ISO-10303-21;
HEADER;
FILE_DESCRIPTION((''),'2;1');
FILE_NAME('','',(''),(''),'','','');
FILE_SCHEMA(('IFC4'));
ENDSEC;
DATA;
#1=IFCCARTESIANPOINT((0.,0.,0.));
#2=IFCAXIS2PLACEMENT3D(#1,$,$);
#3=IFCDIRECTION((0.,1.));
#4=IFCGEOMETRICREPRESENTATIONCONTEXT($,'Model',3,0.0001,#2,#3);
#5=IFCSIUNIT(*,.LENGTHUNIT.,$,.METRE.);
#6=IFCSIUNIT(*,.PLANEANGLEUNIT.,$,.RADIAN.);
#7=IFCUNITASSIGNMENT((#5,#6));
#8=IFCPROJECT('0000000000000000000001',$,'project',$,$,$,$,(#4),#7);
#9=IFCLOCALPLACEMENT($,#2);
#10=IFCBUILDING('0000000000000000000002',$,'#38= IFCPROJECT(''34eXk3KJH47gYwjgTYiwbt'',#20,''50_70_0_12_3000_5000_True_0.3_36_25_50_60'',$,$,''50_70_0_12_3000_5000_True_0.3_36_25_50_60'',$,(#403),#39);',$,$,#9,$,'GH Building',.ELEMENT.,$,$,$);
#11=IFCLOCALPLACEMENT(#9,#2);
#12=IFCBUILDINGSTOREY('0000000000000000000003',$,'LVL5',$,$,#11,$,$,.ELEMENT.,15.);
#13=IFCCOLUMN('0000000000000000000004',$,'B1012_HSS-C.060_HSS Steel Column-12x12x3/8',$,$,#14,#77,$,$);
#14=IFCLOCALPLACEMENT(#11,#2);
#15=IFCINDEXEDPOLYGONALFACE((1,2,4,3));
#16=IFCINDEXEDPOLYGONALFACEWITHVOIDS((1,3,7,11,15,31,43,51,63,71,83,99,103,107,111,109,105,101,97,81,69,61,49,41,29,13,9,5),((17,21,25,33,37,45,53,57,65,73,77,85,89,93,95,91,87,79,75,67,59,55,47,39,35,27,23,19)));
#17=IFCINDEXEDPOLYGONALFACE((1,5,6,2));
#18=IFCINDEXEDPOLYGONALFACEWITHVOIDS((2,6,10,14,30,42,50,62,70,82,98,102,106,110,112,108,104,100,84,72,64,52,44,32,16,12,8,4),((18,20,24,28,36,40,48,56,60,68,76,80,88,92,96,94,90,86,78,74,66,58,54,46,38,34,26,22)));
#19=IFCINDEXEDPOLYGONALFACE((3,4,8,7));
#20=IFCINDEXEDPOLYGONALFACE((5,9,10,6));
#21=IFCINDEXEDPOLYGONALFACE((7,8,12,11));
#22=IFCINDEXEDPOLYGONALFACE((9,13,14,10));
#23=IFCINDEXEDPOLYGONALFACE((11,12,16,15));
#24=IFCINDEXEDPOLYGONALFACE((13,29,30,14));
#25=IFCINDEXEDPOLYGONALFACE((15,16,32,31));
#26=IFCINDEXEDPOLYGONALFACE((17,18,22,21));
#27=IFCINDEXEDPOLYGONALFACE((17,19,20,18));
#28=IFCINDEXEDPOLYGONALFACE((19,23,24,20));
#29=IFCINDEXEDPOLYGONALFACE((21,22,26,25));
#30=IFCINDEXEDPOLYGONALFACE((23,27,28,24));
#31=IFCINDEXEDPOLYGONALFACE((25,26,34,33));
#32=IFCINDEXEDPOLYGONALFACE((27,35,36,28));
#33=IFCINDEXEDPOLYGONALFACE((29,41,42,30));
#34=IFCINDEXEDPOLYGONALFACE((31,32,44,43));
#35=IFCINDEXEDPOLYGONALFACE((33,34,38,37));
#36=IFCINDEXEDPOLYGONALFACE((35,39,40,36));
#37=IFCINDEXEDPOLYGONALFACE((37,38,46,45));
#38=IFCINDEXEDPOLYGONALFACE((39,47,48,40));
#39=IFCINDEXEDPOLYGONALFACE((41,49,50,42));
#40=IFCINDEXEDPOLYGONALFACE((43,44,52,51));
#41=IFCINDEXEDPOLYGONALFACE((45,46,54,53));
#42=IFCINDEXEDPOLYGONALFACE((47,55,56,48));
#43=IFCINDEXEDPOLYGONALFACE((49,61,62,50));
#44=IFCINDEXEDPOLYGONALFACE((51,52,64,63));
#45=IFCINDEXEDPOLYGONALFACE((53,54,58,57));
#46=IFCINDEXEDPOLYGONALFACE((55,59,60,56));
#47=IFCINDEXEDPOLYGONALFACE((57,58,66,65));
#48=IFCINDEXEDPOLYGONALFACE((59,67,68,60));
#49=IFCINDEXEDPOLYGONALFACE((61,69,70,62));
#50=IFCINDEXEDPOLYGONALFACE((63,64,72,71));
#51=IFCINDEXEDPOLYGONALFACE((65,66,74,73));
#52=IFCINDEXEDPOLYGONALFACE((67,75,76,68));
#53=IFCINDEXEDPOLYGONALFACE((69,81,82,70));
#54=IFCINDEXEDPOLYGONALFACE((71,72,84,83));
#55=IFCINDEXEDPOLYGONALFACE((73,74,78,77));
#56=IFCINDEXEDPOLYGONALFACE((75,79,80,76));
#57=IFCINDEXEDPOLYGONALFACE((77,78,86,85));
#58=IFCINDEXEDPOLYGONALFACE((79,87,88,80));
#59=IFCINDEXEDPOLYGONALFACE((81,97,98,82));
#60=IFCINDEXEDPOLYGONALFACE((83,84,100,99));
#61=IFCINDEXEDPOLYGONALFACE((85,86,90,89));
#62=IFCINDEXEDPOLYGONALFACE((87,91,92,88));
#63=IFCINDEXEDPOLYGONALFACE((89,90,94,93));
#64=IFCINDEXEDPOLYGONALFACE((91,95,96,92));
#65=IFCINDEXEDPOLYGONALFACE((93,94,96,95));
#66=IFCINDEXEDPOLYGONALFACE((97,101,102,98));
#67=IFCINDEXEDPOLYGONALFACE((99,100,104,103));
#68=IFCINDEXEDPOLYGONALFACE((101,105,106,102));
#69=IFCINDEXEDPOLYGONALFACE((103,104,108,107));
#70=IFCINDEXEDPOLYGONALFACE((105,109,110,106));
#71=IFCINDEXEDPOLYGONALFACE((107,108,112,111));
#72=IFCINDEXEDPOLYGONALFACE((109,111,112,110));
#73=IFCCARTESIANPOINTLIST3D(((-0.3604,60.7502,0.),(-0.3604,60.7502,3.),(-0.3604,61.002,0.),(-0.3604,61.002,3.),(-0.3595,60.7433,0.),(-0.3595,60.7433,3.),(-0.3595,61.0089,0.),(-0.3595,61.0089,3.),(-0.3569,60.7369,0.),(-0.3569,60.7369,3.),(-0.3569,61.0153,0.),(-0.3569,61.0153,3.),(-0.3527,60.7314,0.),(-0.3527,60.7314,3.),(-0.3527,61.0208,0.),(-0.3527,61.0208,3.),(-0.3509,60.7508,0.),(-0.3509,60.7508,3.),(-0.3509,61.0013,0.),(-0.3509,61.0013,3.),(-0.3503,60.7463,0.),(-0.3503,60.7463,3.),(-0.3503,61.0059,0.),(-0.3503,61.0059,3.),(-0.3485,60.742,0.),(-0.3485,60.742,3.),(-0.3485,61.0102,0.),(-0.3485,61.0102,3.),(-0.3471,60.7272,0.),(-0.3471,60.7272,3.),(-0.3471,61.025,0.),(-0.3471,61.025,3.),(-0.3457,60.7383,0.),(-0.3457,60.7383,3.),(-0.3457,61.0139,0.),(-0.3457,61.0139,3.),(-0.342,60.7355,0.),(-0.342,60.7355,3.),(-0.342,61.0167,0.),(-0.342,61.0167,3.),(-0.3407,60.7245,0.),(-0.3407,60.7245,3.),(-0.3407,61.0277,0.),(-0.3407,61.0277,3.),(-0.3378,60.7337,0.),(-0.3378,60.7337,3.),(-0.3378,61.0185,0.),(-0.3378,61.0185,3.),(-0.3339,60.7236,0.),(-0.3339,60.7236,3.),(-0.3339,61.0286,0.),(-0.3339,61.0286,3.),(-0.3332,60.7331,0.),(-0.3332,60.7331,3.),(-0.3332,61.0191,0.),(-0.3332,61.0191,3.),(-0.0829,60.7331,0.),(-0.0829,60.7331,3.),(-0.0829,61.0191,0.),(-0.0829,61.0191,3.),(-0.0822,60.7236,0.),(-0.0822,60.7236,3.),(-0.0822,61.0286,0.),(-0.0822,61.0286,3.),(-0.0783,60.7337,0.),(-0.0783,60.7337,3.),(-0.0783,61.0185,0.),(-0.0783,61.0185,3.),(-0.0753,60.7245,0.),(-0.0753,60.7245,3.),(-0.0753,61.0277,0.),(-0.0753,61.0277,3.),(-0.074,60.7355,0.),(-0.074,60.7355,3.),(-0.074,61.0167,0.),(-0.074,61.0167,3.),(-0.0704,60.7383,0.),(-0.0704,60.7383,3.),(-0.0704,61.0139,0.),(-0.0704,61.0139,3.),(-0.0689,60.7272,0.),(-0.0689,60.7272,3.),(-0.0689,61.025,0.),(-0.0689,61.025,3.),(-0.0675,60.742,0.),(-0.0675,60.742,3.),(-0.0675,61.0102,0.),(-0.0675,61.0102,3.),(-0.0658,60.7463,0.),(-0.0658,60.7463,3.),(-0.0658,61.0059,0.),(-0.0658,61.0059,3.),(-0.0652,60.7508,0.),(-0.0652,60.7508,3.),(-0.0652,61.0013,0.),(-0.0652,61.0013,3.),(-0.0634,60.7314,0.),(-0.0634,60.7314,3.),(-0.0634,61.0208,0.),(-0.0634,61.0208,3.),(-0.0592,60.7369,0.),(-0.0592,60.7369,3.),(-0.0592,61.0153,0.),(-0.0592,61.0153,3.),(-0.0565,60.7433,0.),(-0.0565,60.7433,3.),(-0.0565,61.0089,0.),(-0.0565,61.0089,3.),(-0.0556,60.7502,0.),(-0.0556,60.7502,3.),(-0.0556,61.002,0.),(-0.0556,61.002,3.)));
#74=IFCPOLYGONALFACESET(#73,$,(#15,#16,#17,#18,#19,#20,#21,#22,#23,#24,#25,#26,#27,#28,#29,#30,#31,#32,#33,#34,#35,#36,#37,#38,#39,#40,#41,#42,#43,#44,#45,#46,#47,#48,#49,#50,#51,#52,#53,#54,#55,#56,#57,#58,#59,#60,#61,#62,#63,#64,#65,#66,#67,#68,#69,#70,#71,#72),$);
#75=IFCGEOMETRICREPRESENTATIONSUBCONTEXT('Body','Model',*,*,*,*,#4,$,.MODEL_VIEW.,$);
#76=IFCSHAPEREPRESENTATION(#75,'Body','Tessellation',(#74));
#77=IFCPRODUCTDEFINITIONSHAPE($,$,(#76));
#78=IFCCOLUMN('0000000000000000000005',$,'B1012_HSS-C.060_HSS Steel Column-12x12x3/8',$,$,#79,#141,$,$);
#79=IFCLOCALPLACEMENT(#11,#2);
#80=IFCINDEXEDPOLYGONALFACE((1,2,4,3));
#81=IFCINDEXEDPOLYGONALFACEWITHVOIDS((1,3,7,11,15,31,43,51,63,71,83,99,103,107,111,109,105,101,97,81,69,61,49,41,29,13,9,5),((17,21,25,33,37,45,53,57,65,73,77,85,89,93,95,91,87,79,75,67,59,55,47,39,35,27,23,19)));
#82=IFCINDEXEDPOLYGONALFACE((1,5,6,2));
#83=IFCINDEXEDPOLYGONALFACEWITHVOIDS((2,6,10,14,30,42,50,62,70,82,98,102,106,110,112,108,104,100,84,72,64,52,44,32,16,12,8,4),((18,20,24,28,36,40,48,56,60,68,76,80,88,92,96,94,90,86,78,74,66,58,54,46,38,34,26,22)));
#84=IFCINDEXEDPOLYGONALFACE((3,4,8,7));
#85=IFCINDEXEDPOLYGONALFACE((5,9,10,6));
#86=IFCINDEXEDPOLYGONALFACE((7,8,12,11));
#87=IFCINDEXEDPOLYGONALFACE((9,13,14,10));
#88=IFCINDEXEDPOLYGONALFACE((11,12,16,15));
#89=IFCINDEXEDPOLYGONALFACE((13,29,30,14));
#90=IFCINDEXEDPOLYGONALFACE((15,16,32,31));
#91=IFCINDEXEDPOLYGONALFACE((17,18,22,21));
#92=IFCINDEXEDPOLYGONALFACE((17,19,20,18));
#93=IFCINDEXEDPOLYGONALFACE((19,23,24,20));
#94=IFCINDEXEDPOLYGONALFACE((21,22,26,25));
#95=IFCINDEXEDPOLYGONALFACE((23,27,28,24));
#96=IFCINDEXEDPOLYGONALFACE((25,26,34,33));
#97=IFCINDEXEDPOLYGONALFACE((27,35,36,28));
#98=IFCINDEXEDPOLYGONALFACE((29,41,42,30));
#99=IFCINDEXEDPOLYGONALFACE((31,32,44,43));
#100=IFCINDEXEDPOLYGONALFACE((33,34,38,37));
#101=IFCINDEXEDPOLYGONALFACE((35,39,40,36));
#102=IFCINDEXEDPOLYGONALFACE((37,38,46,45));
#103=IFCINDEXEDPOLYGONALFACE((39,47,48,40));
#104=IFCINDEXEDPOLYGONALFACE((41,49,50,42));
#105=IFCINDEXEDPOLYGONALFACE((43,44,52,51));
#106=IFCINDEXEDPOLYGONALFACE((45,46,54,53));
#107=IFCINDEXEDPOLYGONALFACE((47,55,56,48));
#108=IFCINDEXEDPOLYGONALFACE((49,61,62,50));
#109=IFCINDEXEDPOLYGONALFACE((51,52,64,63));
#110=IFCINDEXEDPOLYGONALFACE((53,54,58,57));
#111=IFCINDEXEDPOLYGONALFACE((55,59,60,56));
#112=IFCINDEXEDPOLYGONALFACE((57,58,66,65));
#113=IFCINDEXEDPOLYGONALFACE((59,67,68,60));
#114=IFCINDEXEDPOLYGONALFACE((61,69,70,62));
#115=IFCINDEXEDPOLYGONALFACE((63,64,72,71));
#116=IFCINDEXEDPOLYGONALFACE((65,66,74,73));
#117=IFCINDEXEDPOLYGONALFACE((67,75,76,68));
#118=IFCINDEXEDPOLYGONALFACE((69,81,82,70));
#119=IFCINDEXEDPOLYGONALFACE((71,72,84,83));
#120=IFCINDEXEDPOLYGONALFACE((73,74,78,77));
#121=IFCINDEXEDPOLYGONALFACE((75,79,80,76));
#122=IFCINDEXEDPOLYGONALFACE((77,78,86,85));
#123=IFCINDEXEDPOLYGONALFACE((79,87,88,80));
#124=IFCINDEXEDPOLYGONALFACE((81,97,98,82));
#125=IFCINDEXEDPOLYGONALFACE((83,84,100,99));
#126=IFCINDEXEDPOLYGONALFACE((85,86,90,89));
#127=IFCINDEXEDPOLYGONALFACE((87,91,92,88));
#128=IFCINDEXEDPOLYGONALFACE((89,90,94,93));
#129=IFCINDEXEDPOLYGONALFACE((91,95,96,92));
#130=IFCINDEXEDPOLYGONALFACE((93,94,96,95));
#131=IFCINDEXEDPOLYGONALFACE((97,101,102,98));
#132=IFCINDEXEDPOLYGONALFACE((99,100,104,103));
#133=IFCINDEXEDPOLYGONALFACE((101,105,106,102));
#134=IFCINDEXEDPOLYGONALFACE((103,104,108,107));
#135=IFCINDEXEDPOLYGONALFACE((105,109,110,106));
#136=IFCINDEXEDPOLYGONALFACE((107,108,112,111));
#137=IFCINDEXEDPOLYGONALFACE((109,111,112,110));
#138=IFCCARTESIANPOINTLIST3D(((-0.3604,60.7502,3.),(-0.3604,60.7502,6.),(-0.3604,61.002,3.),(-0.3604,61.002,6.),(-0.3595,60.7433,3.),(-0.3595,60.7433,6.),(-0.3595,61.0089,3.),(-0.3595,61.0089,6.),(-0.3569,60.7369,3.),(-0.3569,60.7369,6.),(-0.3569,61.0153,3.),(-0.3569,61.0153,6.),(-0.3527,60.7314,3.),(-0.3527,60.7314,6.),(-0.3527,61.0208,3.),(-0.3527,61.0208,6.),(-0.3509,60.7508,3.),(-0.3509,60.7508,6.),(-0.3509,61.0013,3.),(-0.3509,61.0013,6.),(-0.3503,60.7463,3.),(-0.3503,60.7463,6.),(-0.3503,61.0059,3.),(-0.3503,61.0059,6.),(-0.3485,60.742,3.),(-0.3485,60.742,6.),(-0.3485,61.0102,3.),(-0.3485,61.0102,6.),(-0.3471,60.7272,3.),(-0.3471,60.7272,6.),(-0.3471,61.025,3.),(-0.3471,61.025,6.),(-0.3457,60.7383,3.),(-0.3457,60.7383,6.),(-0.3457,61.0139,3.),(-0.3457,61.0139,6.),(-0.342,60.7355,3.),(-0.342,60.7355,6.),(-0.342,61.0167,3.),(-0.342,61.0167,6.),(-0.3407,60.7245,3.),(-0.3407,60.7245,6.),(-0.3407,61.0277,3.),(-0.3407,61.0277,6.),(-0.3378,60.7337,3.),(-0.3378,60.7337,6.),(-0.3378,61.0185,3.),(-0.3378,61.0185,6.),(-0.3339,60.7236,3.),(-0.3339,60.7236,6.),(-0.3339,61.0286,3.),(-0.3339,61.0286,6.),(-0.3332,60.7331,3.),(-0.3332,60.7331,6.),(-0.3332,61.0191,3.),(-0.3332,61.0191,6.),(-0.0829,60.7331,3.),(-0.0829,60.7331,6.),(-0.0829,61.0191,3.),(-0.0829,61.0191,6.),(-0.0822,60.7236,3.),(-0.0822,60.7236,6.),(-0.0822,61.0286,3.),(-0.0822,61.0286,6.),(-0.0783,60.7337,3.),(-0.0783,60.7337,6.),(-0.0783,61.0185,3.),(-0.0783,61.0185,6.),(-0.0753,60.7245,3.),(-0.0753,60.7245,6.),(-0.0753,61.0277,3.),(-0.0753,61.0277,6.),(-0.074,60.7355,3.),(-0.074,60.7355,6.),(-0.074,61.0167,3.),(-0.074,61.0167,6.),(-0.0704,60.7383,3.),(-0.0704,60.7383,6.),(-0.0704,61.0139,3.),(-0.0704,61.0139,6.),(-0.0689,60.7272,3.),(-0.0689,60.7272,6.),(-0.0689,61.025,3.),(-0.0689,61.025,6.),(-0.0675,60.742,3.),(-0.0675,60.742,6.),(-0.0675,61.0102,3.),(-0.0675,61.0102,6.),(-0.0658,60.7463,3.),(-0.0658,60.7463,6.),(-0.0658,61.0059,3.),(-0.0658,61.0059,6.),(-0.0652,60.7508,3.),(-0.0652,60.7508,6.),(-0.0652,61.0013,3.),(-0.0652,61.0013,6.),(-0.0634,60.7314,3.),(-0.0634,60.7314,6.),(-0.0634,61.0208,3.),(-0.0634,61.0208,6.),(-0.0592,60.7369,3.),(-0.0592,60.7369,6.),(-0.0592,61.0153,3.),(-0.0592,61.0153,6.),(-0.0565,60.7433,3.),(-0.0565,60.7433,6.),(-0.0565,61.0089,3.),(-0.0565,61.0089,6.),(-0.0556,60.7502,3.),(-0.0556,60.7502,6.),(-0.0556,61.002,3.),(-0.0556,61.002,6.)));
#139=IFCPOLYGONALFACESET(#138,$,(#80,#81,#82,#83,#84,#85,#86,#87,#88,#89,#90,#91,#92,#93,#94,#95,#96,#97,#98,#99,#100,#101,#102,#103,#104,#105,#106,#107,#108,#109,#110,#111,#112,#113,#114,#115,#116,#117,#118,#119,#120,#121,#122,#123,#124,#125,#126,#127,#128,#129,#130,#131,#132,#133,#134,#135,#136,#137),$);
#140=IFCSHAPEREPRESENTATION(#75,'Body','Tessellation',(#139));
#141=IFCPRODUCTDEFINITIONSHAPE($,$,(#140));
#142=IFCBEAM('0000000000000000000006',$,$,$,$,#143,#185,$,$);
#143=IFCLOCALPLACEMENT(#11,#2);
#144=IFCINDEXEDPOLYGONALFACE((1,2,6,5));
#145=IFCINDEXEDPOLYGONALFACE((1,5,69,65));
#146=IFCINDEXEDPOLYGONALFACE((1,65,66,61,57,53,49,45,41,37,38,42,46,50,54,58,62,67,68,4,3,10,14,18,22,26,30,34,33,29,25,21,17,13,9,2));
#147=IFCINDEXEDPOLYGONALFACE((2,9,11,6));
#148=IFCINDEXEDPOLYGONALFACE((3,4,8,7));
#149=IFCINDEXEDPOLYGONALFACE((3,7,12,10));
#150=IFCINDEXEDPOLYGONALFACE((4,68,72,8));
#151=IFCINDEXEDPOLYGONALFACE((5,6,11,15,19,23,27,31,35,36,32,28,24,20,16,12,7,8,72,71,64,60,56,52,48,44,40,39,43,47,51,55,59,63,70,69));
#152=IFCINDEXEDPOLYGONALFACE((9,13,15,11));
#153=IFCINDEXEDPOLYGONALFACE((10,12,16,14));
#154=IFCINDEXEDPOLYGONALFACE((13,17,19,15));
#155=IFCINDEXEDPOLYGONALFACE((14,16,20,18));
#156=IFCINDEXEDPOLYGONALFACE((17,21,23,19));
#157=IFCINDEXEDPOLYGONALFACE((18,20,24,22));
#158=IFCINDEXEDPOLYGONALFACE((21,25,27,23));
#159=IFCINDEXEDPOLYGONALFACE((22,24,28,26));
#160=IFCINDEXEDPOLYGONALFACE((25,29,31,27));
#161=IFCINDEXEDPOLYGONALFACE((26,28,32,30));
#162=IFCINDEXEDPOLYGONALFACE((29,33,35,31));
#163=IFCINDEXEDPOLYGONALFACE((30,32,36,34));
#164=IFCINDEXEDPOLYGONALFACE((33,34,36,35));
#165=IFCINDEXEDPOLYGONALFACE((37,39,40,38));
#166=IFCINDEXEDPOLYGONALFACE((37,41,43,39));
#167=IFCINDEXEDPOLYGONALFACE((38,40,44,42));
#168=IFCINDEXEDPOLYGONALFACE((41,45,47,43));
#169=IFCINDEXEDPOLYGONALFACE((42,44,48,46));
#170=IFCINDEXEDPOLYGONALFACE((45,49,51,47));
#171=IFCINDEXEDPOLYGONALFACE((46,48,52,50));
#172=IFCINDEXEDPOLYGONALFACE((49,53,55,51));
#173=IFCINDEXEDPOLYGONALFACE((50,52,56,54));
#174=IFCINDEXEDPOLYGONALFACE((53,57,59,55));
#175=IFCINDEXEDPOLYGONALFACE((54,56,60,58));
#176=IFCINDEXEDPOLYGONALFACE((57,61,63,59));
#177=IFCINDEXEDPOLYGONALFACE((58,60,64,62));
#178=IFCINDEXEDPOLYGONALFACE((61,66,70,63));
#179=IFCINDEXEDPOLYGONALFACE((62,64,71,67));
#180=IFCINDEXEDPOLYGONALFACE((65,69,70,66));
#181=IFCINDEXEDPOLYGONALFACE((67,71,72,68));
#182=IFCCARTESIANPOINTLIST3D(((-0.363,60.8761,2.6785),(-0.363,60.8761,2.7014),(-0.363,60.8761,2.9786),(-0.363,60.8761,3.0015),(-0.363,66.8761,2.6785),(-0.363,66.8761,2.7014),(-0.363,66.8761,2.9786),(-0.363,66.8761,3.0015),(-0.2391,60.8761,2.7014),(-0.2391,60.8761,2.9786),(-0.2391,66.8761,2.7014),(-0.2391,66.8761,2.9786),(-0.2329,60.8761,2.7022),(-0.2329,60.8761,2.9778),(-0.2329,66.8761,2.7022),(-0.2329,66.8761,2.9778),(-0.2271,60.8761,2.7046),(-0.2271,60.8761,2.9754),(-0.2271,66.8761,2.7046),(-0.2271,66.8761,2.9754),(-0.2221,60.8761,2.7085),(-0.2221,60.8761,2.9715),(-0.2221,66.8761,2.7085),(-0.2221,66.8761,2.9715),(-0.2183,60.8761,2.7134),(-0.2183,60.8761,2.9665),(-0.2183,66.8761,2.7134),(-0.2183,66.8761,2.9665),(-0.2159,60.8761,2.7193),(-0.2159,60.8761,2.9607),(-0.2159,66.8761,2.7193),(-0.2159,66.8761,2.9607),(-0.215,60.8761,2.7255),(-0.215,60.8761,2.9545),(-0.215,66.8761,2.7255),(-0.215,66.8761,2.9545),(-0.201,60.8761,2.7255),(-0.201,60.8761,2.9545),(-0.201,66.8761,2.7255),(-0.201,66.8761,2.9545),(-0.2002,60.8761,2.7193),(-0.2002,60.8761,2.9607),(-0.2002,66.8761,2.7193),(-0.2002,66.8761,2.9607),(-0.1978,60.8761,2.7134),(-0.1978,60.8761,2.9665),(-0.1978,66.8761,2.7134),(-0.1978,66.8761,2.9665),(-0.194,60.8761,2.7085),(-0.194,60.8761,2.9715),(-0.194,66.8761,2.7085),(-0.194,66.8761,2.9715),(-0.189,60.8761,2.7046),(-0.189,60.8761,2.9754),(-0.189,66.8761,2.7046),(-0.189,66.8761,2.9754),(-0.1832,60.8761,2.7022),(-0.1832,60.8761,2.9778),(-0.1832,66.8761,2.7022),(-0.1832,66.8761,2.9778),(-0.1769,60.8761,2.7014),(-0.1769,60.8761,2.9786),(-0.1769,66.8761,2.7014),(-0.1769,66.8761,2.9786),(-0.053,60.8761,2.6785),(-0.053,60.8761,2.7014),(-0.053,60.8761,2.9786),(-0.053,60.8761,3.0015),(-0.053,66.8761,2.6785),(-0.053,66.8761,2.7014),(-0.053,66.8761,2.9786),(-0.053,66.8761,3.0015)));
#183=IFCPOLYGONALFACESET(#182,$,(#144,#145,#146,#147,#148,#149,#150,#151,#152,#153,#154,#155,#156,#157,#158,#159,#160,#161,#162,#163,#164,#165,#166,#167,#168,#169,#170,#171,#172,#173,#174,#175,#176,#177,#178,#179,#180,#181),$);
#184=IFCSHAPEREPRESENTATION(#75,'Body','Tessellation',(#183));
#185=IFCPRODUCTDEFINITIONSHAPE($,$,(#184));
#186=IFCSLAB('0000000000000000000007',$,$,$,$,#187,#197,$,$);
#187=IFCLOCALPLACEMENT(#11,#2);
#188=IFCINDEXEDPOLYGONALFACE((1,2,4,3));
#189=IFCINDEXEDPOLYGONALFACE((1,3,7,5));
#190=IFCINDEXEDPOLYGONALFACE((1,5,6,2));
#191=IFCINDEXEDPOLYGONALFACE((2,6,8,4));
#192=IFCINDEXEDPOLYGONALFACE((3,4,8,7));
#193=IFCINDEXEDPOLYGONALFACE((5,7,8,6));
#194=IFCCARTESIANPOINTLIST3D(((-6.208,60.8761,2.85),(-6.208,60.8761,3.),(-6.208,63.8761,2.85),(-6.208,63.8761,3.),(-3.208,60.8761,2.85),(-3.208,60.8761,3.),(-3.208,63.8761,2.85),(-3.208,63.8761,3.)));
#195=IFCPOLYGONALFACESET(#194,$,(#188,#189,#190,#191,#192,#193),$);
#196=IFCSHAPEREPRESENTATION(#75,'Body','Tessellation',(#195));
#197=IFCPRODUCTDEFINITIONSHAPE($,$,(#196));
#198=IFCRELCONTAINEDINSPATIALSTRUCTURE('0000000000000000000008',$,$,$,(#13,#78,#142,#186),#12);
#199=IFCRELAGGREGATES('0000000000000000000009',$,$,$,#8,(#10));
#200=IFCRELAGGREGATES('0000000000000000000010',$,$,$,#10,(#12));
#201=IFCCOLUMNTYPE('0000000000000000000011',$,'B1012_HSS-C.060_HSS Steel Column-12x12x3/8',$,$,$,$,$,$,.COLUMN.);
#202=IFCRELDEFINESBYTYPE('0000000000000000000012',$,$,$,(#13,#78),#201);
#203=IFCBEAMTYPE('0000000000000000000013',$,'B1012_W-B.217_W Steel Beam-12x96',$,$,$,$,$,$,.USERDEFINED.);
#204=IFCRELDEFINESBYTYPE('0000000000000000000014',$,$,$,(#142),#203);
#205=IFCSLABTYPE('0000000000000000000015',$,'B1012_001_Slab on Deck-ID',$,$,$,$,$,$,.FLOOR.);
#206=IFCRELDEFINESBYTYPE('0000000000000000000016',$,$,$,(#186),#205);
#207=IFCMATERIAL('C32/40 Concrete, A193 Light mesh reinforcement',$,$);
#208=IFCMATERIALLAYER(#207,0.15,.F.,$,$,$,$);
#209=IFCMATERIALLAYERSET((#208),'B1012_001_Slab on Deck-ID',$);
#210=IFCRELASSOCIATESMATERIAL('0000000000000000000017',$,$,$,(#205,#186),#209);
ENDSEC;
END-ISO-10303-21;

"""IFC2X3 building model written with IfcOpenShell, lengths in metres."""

from ifc_helpers import new_model, si_unit, direction, frame, origin, origin_2d, place, context, subcontext, project, spatial, polyline, hollow_rectangle, i_section, outline, extrude, material, layer, layer_set, layer_usage, type_object, element, save


model = new_model("IFC2X3")

# Units and contexts
model_context = context("Model", 3, precision=0.0001, world=origin(), true_north=direction((0.0, 1.0)))
body_context = subcontext(model_context, "Body", "Model", "MODEL_VIEW")
ifc_project = project(units=[si_unit("LENGTHUNIT", "METRE"), si_unit("PLANEANGLEUNIT", "RADIAN")], contexts=[model_context])

# Building, storey
building_placement = place(None, origin())
building = spatial("IfcBuilding", under=ifc_project, at=building_placement, Name="#38= IFCPROJECT('34eXk3KJH47gYwjgTYiwbt',#20,'50_70_0_12_3000_5000_True_0.3_36_25_50_60',$,$,'50_70_0_12_3000_5000_True_0.3_36_25_50_60',$,(#403),#39);", LongName="GH Building", CompositionType="ELEMENT")
storey_placement = place(building_placement, origin())
storey = spatial("IfcBuildingStorey", under=building, at=storey_placement, Name="LVL5", CompositionType="ELEMENT", Elevation=15.0)

# Columns
column_type = type_object("IfcColumnType", Name="B1012_HSS-C.060_HSS Steel Column-12x12x3/8", PredefinedType="COLUMN")
for number, where, z_axis, x_axis, name in (
    (1, (-0.208, 60.8761, 3.0), (0.0, 0.0, -1.0), (-1.0, 0.0, 0.0), "B1012_HSS-C.060_HSS Steel Column-12x12x3/8"),
    (2, (-0.208, 60.8761, 6.0), (0.0, 0.0, -1.0), (-1.0, 0.0, 0.0), "B1012_HSS-C.060_HSS Steel Column-12x12x3/8"),
):
    element("IfcColumn", number, at=place(storey_placement, frame(where, z_axis=z_axis, x_axis=x_axis)), inside=storey, type_object=column_type, Name=name, context=body_context, shape_type="SweptSolid", body=[
        extrude(hollow_rectangle(XDim=0.3048, YDim=0.305, WallThickness=0.0095, InnerFilletRadius=0.0177, OuterFilletRadius=0.0266, at=origin_2d()), origin(), (0.0, 0.0, 1.0), 3.0),
    ])

# Beam
beam_type = type_object("IfcBeamType", Name="B1012_W-B.217_W Steel Beam-12x96", PredefinedType="USERDEFINED")
beam_placement = place(storey_placement, frame((-0.208, 60.8761, 2.84), z_axis=(0.0, 1.0, 0.0), x_axis=(-1.0, 0.0, 0.0)))
element("IfcBeam", 3, at=beam_placement, inside=storey, type_object=beam_type, context=body_context, shape_type="SweptSolid", body=[
    extrude(i_section(OverallWidth=0.31, OverallDepth=0.323, WebThickness=0.014, FlangeThickness=0.0229, FilletRadius=0.0241, at=origin_2d()), origin(), (0.0, 0.0, 1.0), 6.0),
])

# Slab
ifc_material_1 = material(Name="C32/40 Concrete, A193 Light mesh reinforcement")
ifc_layer_1 = layer(ifc_material_1, 0.15, ventilated=False)
ifc_layer_set_1 = layer_set([ifc_layer_1], Name="B1012_001_Slab on Deck-ID")
ifc_layer_usage_1 = layer_usage(ifc_layer_set_1, "AXIS3", "NEGATIVE", -0.15)
slab_type_1 = type_object("IfcSlabType", Name="B1012_001_Slab on Deck-ID", PredefinedType="FLOOR", material=ifc_layer_set_1)
slab_1_placement = place(storey_placement, frame((-4.708, 62.3761, 2.85)))
element("IfcSlab", 4, at=slab_1_placement, inside=storey, type_object=slab_type_1, material=ifc_layer_usage_1, context=body_context, shape_type="SweptSolid", body=[
    extrude(outline(polyline([(1.5, -1.5), (-1.5, -1.5), (-1.5, 1.5), (1.5, 1.5), (1.5, -1.5)])), origin(), (0.0, 0.0, 1.0), 0.15),
])

save(model, "model.ifc")
